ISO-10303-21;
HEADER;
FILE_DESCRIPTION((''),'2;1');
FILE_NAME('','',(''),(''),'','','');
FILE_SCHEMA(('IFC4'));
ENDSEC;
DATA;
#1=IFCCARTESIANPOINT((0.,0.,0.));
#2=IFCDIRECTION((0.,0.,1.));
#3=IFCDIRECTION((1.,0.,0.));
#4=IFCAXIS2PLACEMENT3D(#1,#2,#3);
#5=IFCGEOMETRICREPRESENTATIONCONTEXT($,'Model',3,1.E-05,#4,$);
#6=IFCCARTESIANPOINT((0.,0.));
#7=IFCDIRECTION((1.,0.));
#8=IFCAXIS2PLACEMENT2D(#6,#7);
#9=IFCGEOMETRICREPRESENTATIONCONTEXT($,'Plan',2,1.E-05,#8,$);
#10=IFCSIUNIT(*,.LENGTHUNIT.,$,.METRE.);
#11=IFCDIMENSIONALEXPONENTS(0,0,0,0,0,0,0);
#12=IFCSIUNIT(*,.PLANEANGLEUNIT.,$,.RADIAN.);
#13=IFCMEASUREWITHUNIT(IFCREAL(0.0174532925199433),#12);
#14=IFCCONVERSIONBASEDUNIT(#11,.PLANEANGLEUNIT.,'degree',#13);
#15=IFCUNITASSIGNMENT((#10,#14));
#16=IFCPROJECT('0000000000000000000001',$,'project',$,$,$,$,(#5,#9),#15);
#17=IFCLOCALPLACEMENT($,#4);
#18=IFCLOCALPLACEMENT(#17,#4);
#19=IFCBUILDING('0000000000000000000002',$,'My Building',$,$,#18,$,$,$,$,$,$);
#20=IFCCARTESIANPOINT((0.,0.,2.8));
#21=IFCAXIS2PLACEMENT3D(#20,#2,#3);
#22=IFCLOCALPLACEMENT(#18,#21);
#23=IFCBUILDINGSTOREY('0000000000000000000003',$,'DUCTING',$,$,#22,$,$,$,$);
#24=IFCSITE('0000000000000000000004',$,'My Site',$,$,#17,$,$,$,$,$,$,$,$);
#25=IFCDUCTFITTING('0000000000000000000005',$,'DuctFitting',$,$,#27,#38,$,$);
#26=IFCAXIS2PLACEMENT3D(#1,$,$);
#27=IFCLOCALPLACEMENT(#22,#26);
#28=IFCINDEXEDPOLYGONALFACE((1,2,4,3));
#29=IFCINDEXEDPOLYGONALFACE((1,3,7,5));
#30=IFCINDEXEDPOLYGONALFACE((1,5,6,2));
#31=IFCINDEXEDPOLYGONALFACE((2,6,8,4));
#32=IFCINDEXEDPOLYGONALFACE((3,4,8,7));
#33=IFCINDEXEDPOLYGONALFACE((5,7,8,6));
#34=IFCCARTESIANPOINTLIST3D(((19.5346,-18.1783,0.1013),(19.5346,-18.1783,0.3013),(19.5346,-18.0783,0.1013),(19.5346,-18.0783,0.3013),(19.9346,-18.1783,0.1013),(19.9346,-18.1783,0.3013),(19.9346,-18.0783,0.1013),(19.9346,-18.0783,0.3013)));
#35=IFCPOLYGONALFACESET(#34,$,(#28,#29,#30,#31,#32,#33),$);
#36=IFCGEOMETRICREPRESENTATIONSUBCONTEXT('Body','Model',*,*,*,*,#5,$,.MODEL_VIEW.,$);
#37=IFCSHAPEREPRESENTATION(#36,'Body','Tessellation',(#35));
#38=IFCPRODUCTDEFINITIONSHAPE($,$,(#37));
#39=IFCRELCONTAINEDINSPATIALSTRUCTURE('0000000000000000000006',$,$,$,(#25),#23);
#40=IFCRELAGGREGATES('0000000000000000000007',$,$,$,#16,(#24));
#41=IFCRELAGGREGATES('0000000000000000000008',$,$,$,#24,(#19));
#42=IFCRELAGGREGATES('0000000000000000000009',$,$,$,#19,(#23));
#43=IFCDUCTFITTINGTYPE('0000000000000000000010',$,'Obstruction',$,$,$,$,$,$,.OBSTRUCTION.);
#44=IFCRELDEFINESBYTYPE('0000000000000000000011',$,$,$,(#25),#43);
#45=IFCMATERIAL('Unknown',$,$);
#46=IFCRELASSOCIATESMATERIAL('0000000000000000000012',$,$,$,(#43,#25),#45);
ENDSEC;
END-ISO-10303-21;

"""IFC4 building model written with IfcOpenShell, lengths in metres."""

from ifc_helpers import new_model, entity, si_unit, converted_unit, frame, origin_with_axes, origin_2d_with_axis, place, context, subcontext, project, spatial, rectangle, extrude, material, material_profile, profile_set, profile_usage, type_object, element, save


model = new_model("IFC4")

# Units and contexts
model_context = context("Model", 3, precision=1e-05, world=origin_with_axes())
plan_context = context("Plan", 2, precision=1e-05, world=origin_2d_with_axis())
body_context = subcontext(model_context, "Body", "Model", "MODEL_VIEW")
ifc_project = project(units=[si_unit("LENGTHUNIT", "METRE"), converted_unit("PLANEANGLEUNIT", "degree", entity("IfcReal", 0.0174532925199433), si_unit("PLANEANGLEUNIT", "RADIAN"), dimensions=[0, 0, 0, 0, 0, 0, 0])], contexts=[model_context, plan_context])

# Site, building, storey
site_placement = place(None, origin_with_axes())
site = spatial("IfcSite", under=ifc_project, at=site_placement, Name="My Site")
building_placement = place(site_placement, origin_with_axes())
building = spatial("IfcBuilding", under=site, at=building_placement, Name="My Building")
storey_placement = place(building_placement, frame((0.0, 0.0, 2.8), z_axis=(0.0, 0.0, 1.0), x_axis=(1.0, 0.0, 0.0)))
storey = spatial("IfcBuildingStorey", under=building, at=storey_placement, Name="DUCTING")

# Shared definitions
ifc_material = material(Name="Unknown")

# Duct fitting
ifc_material_profile_1 = material_profile(ifc_material, rectangle(XDim=0.4, YDim=0.2))
ifc_profile_set_1 = profile_set([ifc_material_profile_1])
duct_fitting_type_1 = type_object("IfcDuctFittingType", Name="Obstruction", PredefinedType="OBSTRUCTION", material=ifc_profile_set_1)
ifc_profile_usage_1 = profile_usage(ifc_profile_set_1, cardinal=5)
duct_fitting_1_placement = place(storey_placement, frame((19.7346, -18.0783, 0.2013), z_axis=(0.0, -1.0, 0.0), x_axis=(1.0, 0.0, 0.0)))
element("IfcDuctFitting", 1, at=duct_fitting_1_placement, inside=storey, type_object=duct_fitting_type_1, material=ifc_profile_usage_1, Name="DuctFitting", context=body_context, shape_type="SweptSolid", body=[
    extrude(rectangle(XDim=0.4, YDim=0.2), origin_with_axes(), (0.0, 0.0, 1.0), 0.1),
])

save(model, "model.ifc")
